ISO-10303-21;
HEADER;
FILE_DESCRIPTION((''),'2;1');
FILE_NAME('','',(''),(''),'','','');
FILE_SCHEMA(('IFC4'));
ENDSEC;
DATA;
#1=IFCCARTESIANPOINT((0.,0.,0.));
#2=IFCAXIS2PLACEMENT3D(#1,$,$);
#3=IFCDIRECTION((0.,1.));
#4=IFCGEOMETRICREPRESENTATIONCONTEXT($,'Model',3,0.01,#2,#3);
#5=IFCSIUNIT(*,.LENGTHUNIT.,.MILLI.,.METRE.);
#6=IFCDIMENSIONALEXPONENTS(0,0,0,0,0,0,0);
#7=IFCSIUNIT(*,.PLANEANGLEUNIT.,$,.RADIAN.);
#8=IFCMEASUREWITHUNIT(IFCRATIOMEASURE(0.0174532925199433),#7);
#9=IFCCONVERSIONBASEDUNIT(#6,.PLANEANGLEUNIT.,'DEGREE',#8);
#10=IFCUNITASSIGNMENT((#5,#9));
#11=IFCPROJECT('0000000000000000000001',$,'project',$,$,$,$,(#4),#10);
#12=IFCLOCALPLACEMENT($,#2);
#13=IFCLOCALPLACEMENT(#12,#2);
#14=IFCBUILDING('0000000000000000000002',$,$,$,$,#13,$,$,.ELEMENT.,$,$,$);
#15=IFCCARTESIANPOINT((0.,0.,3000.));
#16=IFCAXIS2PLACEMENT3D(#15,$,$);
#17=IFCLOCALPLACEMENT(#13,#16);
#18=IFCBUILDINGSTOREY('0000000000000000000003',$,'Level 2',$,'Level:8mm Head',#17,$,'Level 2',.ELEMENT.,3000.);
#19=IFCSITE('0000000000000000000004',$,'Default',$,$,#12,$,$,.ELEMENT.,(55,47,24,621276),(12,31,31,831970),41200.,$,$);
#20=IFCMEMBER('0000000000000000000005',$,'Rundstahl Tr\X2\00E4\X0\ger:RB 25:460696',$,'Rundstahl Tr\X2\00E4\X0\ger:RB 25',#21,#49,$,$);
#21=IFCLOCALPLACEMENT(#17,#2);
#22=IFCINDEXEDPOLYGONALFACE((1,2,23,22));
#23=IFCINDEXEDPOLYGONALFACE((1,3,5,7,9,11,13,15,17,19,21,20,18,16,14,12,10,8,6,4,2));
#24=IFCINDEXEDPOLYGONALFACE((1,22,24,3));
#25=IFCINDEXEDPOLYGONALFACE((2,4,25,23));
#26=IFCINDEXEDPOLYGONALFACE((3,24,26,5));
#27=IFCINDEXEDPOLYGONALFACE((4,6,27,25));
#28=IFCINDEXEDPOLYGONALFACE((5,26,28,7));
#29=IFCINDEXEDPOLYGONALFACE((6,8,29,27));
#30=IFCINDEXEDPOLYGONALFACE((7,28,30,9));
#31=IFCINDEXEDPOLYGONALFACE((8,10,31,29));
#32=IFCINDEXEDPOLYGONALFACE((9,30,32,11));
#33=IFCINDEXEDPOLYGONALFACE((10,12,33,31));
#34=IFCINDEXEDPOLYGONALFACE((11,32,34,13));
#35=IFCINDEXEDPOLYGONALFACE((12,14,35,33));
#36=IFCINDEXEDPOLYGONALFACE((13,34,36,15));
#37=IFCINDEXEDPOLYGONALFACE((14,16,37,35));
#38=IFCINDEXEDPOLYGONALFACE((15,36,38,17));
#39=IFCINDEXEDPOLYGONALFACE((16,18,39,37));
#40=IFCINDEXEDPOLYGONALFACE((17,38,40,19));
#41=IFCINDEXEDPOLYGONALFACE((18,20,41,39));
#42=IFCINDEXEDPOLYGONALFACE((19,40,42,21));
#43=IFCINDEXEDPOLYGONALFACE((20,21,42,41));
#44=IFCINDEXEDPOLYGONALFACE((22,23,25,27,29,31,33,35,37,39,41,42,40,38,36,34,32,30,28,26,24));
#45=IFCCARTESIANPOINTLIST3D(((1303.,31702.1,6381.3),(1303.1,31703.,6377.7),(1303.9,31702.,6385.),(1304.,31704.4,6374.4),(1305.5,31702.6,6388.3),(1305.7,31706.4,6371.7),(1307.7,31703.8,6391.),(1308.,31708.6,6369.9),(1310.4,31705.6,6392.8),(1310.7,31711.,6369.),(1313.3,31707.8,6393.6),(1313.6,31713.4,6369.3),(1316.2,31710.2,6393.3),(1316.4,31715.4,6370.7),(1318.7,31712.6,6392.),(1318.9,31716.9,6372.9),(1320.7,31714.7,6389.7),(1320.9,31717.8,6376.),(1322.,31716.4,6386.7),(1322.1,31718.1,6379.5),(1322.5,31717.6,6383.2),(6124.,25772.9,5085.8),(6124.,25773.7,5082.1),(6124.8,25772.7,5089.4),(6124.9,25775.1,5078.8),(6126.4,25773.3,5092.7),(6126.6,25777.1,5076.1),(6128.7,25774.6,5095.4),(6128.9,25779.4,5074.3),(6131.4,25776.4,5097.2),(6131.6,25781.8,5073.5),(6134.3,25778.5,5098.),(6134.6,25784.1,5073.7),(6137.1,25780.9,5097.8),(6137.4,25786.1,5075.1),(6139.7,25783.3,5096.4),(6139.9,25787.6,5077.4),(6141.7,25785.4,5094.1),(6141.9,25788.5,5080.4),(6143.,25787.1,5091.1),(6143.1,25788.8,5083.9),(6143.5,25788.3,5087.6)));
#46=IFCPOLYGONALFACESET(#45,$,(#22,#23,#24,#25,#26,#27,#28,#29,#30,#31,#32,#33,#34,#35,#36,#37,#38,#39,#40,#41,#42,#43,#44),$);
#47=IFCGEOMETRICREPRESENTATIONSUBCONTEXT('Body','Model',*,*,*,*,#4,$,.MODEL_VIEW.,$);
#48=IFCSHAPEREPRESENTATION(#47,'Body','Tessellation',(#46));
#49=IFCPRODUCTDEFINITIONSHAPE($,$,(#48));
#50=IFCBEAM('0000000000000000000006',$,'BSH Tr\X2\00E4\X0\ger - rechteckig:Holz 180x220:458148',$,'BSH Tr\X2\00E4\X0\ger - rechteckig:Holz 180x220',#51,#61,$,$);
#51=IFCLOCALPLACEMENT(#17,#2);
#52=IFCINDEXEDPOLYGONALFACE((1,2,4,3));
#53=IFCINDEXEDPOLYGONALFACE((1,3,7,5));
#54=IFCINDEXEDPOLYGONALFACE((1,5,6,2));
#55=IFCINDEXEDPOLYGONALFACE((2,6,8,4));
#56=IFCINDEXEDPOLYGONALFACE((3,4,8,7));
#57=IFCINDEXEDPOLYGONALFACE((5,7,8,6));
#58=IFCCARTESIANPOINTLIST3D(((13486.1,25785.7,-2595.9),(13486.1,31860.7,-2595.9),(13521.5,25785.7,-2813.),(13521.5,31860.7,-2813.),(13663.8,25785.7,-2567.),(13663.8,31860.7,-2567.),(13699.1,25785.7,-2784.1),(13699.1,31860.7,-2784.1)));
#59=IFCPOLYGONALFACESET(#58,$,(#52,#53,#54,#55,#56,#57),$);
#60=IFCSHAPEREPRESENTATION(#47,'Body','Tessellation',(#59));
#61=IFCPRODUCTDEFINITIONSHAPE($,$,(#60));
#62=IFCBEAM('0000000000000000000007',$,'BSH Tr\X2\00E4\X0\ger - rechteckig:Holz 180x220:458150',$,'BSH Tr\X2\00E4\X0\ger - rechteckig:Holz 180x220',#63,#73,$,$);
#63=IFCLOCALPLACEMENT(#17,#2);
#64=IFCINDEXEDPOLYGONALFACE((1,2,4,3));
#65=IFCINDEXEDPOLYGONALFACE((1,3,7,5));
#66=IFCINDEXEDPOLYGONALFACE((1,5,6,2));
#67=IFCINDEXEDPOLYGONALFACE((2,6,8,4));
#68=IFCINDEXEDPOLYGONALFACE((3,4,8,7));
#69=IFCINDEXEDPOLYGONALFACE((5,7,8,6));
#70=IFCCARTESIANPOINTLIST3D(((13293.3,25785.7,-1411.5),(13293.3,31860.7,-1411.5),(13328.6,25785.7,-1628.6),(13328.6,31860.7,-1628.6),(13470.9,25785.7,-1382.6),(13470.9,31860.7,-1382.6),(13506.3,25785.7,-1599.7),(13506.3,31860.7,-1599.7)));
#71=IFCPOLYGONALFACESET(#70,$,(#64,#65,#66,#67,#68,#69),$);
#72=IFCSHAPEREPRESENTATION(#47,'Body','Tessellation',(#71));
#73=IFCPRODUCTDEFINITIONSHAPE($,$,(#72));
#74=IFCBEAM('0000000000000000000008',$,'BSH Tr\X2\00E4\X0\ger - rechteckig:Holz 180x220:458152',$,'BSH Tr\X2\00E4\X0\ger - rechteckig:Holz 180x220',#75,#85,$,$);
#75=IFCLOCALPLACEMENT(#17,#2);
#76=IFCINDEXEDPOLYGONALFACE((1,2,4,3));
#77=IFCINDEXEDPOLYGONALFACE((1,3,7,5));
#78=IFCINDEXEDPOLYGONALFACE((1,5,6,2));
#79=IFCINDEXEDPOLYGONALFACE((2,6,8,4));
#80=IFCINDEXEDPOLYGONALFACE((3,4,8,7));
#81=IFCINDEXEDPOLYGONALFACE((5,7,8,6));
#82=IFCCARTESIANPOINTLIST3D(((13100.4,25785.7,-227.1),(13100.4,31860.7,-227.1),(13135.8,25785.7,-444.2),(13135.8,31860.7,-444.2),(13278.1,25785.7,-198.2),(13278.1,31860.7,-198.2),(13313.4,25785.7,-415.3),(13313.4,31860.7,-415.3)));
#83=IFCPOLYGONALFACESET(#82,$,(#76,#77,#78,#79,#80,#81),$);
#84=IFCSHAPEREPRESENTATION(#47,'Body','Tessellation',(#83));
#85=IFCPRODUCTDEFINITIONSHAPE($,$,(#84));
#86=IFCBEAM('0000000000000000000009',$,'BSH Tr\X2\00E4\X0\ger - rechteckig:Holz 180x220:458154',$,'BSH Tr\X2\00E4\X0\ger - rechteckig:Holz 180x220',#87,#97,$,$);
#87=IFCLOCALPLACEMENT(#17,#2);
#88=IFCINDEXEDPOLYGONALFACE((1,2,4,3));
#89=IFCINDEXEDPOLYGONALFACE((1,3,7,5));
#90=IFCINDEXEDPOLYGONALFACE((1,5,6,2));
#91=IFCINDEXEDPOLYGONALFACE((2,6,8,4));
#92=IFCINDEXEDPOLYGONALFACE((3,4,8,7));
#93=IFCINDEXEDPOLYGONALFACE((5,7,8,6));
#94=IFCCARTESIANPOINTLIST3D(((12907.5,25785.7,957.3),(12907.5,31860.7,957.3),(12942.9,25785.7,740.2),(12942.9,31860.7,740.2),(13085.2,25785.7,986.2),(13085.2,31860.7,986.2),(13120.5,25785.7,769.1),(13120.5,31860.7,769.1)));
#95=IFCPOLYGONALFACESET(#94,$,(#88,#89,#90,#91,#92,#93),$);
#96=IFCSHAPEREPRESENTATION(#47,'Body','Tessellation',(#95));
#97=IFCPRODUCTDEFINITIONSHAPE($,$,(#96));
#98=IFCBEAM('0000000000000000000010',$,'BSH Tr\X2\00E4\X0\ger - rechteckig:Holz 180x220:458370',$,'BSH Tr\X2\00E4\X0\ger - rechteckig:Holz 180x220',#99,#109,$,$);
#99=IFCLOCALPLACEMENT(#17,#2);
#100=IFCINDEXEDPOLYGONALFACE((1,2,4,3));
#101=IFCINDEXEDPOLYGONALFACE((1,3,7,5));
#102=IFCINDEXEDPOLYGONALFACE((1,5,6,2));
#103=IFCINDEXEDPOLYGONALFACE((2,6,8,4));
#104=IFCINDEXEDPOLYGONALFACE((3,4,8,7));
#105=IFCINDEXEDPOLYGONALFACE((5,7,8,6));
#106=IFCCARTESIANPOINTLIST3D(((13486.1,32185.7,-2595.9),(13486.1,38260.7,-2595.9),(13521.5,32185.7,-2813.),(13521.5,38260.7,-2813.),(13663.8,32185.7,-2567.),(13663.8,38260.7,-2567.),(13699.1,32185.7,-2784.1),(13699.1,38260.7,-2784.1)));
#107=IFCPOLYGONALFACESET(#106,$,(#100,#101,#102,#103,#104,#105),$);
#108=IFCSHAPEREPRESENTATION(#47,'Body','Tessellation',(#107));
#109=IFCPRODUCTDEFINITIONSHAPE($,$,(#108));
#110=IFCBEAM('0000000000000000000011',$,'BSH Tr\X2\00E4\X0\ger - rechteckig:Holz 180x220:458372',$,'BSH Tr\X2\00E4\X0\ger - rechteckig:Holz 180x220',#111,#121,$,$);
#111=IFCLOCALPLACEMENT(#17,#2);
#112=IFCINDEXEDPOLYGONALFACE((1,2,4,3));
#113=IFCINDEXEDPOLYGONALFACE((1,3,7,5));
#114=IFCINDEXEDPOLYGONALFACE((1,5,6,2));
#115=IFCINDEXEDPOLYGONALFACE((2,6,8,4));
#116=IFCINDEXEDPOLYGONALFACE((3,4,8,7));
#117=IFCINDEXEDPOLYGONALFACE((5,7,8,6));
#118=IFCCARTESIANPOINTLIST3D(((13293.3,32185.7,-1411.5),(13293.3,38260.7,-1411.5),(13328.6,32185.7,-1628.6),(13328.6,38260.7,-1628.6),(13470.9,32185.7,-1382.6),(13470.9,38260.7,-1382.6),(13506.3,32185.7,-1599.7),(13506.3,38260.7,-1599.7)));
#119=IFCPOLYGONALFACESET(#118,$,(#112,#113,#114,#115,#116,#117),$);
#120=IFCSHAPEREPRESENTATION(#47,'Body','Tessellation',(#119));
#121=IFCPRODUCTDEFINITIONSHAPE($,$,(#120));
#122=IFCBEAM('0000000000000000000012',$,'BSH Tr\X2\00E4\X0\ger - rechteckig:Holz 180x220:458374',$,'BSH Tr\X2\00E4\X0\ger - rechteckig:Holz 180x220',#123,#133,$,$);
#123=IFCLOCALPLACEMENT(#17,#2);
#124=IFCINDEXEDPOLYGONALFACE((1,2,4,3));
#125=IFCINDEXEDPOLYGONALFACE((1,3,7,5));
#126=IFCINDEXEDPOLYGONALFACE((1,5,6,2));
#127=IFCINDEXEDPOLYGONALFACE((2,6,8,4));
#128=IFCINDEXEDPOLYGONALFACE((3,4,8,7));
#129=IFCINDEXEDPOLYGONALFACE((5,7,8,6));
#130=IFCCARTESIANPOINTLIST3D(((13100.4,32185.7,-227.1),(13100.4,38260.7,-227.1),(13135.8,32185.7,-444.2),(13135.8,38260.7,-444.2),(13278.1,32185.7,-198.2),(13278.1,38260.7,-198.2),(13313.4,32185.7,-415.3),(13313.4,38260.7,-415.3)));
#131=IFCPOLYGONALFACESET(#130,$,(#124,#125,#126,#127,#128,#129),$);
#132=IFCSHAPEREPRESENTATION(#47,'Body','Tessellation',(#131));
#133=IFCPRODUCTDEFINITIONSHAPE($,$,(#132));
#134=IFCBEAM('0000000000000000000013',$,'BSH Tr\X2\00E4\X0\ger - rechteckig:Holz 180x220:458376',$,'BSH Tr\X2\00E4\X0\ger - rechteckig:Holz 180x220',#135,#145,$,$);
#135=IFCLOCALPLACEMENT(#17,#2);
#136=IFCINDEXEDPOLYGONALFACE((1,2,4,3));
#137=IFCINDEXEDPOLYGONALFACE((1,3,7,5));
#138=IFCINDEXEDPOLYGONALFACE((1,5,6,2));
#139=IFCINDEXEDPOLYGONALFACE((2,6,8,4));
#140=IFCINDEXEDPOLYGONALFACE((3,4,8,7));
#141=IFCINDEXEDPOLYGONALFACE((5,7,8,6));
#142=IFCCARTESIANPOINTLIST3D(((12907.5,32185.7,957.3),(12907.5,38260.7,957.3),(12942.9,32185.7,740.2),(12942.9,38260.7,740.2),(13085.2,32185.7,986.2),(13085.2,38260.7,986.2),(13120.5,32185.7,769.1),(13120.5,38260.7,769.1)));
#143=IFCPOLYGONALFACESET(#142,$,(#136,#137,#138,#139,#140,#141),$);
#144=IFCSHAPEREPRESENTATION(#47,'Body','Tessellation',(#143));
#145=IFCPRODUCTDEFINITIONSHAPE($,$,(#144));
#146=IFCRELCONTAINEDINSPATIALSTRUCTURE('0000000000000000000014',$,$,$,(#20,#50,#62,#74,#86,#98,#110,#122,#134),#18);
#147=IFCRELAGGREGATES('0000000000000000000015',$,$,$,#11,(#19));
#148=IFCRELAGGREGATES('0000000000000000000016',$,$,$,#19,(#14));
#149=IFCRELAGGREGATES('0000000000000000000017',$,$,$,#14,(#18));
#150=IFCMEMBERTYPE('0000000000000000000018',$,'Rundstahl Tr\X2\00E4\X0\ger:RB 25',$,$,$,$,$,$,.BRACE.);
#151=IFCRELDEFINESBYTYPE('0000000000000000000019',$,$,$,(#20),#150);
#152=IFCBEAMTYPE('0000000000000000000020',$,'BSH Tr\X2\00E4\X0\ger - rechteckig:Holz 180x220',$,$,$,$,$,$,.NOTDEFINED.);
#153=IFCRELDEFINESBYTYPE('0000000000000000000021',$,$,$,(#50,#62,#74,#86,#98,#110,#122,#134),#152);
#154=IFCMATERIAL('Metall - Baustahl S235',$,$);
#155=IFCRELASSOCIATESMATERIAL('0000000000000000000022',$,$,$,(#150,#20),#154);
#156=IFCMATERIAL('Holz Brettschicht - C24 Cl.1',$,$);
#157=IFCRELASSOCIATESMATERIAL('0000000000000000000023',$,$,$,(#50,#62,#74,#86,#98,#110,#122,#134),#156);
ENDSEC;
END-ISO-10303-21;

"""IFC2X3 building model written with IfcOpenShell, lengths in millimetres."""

from ifc_helpers import new_model, entity, si_unit, converted_unit, direction, frame, frame_2d, origin, place, context, subcontext, project, spatial, rectangle, circle, extrude, source, transform, mapped, material, type_object, type_shapes, element, save


model = new_model("IFC2X3")

# Units and contexts
model_context = context("Model", 3, precision=0.01, world=origin(), true_north=direction((0.0, 1.0)))
body_context = subcontext(model_context, "Body", "Model", "MODEL_VIEW")
ifc_project = project(units=[si_unit("LENGTHUNIT", "METRE", prefix="MILLI"), converted_unit("PLANEANGLEUNIT", "DEGREE", entity("IfcRatioMeasure", 0.0174532925199433), si_unit("PLANEANGLEUNIT", "RADIAN"), dimensions=[0, 0, 0, 0, 0, 0, 0])], contexts=[model_context])

# Site, building, storey
site_placement = place(None, origin())
site = spatial("IfcSite", under=ifc_project, at=site_placement, Name="Default", CompositionType="ELEMENT", RefLatitude=(55, 47, 24, 621276), RefLongitude=(12, 31, 31, 831970), RefElevation=41200.0)
building_placement = place(site_placement, origin())
building = spatial("IfcBuilding", under=site, at=building_placement, CompositionType="ELEMENT")
storey_placement = place(building_placement, frame((0.0, 0.0, 3000.0)))
storey = spatial("IfcBuildingStorey", under=building, at=storey_placement, Name="Level 2", ObjectType="Level:8mm Head", LongName="Level 2", CompositionType="ELEMENT", Elevation=3000.0)

# Member
ifc_material_1 = material(Name="Metall - Baustahl S235")
member_type_1 = type_object("IfcMemberType", Name="Rundstahl Träger:RB 25", PredefinedType="BRACE", material=ifc_material_1)
shared_shape_1 = source(origin(), body_context, "Body", "SweptSolid", [
    extrude(circle(Radius=12.5, at=frame_2d((0.0, 0.0), x_axis=(1.0, 0.0))), frame((-3875.1, 0.0, 0.0), z_axis=(1.0, 0.0, 0.0), x_axis=(0.0, -1.0, 0.0)), (0.0, 0.0, 1.0), 7750.9),
])
type_shapes(member_type_1, [shared_shape_1])
member_1_placement = place(storey_placement, frame((3723.0, 28745.6, 5733.6), z_axis=(0.105449, -0.129691, 0.985931), x_axis=(0.621987, -0.764979, -0.167151)))
element("IfcMember", 1, at=member_1_placement, inside=storey, type_object=member_type_1, material=ifc_material_1, Name="Rundstahl Träger:RB 25:460696", ObjectType="Rundstahl Träger:RB 25", context=body_context, shape_type="MappedRepresentation", body=[
    mapped(shared_shape_1, transform((0.0, 0.0, 0.0), scale=1.0)),
])

# Beams
ifc_material_2 = material(Name="Holz Brettschicht - C24 Cl.1")
beam_type_1 = type_object("IfcBeamType", Name="BSH Träger - rechteckig:Holz 180x220", PredefinedType="NOTDEFINED")
beam_1_placement = place(storey_placement, frame((13681.5, 26523.2, -2675.5), z_axis=(0.0, 0.0, 1.0), x_axis=(0.0, 1.0, 0.0)))
element("IfcBeam", 2, at=beam_1_placement, inside=storey, type_object=beam_type_1, material=ifc_material_2, Name="BSH Träger - rechteckig:Holz 180x220:458148", ObjectType="BSH Träger - rechteckig:Holz 180x220", context=body_context, shape_type="SweptSolid", body=[
    extrude(rectangle(XDim=220.0, YDim=180.0, at=frame_2d((0.0, 0.0), x_axis=(1.0, 0.0))), frame((-737.5, 88.8, -14.5), z_axis=(1.0, 0.0, 0.0), x_axis=(0.0, 0.160724, 0.986999)), (0.0, 0.0, 1.0), 6075.0),
])
beam_2_placement = place(storey_placement, frame((13488.6, 26523.2, -1491.1), z_axis=(0.0, 0.0, 1.0), x_axis=(0.0, 1.0, 0.0)))
element("IfcBeam", 3, at=beam_2_placement, inside=storey, type_object=beam_type_1, material=ifc_material_2, Name="BSH Träger - rechteckig:Holz 180x220:458150", ObjectType="BSH Träger - rechteckig:Holz 180x220", context=body_context, shape_type="SweptSolid", body=[
    extrude(rectangle(XDim=220.0, YDim=180.0, at=frame_2d((0.0, 0.0), x_axis=(1.0, 0.0))), frame((-737.5, 88.8, -14.5), z_axis=(1.0, 0.0, 0.0), x_axis=(0.0, 0.160724, 0.986999)), (0.0, 0.0, 1.0), 6075.0),
])
beam_3_placement = place(storey_placement, frame((13295.7, 26523.2, -306.7), z_axis=(0.0, 0.0, 1.0), x_axis=(0.0, 1.0, 0.0)))
element("IfcBeam", 4, at=beam_3_placement, inside=storey, type_object=beam_type_1, material=ifc_material_2, Name="BSH Träger - rechteckig:Holz 180x220:458152", ObjectType="BSH Träger - rechteckig:Holz 180x220", context=body_context, shape_type="SweptSolid", body=[
    extrude(rectangle(XDim=220.0, YDim=180.0, at=frame_2d((0.0, 0.0), x_axis=(1.0, 0.0))), frame((-737.5, 88.8, -14.5), z_axis=(1.0, 0.0, 0.0), x_axis=(0.0, 0.160724, 0.986999)), (0.0, 0.0, 1.0), 6075.0),
])
beam_4_placement = place(storey_placement, frame((13102.9, 26523.2, 877.7), z_axis=(0.0, 0.0, 1.0), x_axis=(0.0, 1.0, 0.0)))
element("IfcBeam", 5, at=beam_4_placement, inside=storey, type_object=beam_type_1, material=ifc_material_2, Name="BSH Träger - rechteckig:Holz 180x220:458154", ObjectType="BSH Träger - rechteckig:Holz 180x220", context=body_context, shape_type="SweptSolid", body=[
    extrude(rectangle(XDim=220.0, YDim=180.0, at=frame_2d((0.0, 0.0), x_axis=(1.0, 0.0))), frame((-737.5, 88.8, -14.5), z_axis=(1.0, 0.0, 0.0), x_axis=(0.0, 0.160724, 0.986999)), (0.0, 0.0, 1.0), 6075.0),
])
beam_5_placement = place(storey_placement, frame((13681.5, 32923.2, -2675.5), z_axis=(0.0, 0.0, 1.0), x_axis=(0.0, 1.0, 0.0)))
element("IfcBeam", 6, at=beam_5_placement, inside=storey, type_object=beam_type_1, material=ifc_material_2, Name="BSH Träger - rechteckig:Holz 180x220:458370", ObjectType="BSH Träger - rechteckig:Holz 180x220", context=body_context, shape_type="SweptSolid", body=[
    extrude(rectangle(XDim=220.0, YDim=180.0, at=frame_2d((0.0, 0.0), x_axis=(1.0, 0.0))), frame((-737.5, 88.8, -14.5), z_axis=(1.0, 0.0, 0.0), x_axis=(0.0, 0.160724, 0.986999)), (0.0, 0.0, 1.0), 6075.0),
])
beam_6_placement = place(storey_placement, frame((13488.6, 32923.2, -1491.1), z_axis=(0.0, 0.0, 1.0), x_axis=(0.0, 1.0, 0.0)))
element("IfcBeam", 7, at=beam_6_placement, inside=storey, type_object=beam_type_1, material=ifc_material_2, Name="BSH Träger - rechteckig:Holz 180x220:458372", ObjectType="BSH Träger - rechteckig:Holz 180x220", context=body_context, shape_type="SweptSolid", body=[
    extrude(rectangle(XDim=220.0, YDim=180.0, at=frame_2d((0.0, 0.0), x_axis=(1.0, 0.0))), frame((-737.5, 88.8, -14.5), z_axis=(1.0, 0.0, 0.0), x_axis=(0.0, 0.160724, 0.986999)), (0.0, 0.0, 1.0), 6075.0),
])
beam_7_placement = place(storey_placement, frame((13295.7, 32923.2, -306.7), z_axis=(0.0, 0.0, 1.0), x_axis=(0.0, 1.0, 0.0)))
element("IfcBeam", 8, at=beam_7_placement, inside=storey, type_object=beam_type_1, material=ifc_material_2, Name="BSH Träger - rechteckig:Holz 180x220:458374", ObjectType="BSH Träger - rechteckig:Holz 180x220", context=body_context, shape_type="SweptSolid", body=[
    extrude(rectangle(XDim=220.0, YDim=180.0, at=frame_2d((0.0, 0.0), x_axis=(1.0, 0.0))), frame((-737.5, 88.8, -14.5), z_axis=(1.0, 0.0, 0.0), x_axis=(0.0, 0.160724, 0.986999)), (0.0, 0.0, 1.0), 6075.0),
])
beam_8_placement = place(storey_placement, frame((13102.9, 32923.2, 877.7), z_axis=(0.0, 0.0, 1.0), x_axis=(0.0, 1.0, 0.0)))
element("IfcBeam", 9, at=beam_8_placement, inside=storey, type_object=beam_type_1, material=ifc_material_2, Name="BSH Träger - rechteckig:Holz 180x220:458376", ObjectType="BSH Träger - rechteckig:Holz 180x220", context=body_context, shape_type="SweptSolid", body=[
    extrude(rectangle(XDim=220.0, YDim=180.0, at=frame_2d((0.0, 0.0), x_axis=(1.0, 0.0))), frame((-737.5, 88.8, -14.5), z_axis=(1.0, 0.0, 0.0), x_axis=(0.0, 0.160724, 0.986999)), (0.0, 0.0, 1.0), 6075.0),
])

save(model, "model.ifc")
